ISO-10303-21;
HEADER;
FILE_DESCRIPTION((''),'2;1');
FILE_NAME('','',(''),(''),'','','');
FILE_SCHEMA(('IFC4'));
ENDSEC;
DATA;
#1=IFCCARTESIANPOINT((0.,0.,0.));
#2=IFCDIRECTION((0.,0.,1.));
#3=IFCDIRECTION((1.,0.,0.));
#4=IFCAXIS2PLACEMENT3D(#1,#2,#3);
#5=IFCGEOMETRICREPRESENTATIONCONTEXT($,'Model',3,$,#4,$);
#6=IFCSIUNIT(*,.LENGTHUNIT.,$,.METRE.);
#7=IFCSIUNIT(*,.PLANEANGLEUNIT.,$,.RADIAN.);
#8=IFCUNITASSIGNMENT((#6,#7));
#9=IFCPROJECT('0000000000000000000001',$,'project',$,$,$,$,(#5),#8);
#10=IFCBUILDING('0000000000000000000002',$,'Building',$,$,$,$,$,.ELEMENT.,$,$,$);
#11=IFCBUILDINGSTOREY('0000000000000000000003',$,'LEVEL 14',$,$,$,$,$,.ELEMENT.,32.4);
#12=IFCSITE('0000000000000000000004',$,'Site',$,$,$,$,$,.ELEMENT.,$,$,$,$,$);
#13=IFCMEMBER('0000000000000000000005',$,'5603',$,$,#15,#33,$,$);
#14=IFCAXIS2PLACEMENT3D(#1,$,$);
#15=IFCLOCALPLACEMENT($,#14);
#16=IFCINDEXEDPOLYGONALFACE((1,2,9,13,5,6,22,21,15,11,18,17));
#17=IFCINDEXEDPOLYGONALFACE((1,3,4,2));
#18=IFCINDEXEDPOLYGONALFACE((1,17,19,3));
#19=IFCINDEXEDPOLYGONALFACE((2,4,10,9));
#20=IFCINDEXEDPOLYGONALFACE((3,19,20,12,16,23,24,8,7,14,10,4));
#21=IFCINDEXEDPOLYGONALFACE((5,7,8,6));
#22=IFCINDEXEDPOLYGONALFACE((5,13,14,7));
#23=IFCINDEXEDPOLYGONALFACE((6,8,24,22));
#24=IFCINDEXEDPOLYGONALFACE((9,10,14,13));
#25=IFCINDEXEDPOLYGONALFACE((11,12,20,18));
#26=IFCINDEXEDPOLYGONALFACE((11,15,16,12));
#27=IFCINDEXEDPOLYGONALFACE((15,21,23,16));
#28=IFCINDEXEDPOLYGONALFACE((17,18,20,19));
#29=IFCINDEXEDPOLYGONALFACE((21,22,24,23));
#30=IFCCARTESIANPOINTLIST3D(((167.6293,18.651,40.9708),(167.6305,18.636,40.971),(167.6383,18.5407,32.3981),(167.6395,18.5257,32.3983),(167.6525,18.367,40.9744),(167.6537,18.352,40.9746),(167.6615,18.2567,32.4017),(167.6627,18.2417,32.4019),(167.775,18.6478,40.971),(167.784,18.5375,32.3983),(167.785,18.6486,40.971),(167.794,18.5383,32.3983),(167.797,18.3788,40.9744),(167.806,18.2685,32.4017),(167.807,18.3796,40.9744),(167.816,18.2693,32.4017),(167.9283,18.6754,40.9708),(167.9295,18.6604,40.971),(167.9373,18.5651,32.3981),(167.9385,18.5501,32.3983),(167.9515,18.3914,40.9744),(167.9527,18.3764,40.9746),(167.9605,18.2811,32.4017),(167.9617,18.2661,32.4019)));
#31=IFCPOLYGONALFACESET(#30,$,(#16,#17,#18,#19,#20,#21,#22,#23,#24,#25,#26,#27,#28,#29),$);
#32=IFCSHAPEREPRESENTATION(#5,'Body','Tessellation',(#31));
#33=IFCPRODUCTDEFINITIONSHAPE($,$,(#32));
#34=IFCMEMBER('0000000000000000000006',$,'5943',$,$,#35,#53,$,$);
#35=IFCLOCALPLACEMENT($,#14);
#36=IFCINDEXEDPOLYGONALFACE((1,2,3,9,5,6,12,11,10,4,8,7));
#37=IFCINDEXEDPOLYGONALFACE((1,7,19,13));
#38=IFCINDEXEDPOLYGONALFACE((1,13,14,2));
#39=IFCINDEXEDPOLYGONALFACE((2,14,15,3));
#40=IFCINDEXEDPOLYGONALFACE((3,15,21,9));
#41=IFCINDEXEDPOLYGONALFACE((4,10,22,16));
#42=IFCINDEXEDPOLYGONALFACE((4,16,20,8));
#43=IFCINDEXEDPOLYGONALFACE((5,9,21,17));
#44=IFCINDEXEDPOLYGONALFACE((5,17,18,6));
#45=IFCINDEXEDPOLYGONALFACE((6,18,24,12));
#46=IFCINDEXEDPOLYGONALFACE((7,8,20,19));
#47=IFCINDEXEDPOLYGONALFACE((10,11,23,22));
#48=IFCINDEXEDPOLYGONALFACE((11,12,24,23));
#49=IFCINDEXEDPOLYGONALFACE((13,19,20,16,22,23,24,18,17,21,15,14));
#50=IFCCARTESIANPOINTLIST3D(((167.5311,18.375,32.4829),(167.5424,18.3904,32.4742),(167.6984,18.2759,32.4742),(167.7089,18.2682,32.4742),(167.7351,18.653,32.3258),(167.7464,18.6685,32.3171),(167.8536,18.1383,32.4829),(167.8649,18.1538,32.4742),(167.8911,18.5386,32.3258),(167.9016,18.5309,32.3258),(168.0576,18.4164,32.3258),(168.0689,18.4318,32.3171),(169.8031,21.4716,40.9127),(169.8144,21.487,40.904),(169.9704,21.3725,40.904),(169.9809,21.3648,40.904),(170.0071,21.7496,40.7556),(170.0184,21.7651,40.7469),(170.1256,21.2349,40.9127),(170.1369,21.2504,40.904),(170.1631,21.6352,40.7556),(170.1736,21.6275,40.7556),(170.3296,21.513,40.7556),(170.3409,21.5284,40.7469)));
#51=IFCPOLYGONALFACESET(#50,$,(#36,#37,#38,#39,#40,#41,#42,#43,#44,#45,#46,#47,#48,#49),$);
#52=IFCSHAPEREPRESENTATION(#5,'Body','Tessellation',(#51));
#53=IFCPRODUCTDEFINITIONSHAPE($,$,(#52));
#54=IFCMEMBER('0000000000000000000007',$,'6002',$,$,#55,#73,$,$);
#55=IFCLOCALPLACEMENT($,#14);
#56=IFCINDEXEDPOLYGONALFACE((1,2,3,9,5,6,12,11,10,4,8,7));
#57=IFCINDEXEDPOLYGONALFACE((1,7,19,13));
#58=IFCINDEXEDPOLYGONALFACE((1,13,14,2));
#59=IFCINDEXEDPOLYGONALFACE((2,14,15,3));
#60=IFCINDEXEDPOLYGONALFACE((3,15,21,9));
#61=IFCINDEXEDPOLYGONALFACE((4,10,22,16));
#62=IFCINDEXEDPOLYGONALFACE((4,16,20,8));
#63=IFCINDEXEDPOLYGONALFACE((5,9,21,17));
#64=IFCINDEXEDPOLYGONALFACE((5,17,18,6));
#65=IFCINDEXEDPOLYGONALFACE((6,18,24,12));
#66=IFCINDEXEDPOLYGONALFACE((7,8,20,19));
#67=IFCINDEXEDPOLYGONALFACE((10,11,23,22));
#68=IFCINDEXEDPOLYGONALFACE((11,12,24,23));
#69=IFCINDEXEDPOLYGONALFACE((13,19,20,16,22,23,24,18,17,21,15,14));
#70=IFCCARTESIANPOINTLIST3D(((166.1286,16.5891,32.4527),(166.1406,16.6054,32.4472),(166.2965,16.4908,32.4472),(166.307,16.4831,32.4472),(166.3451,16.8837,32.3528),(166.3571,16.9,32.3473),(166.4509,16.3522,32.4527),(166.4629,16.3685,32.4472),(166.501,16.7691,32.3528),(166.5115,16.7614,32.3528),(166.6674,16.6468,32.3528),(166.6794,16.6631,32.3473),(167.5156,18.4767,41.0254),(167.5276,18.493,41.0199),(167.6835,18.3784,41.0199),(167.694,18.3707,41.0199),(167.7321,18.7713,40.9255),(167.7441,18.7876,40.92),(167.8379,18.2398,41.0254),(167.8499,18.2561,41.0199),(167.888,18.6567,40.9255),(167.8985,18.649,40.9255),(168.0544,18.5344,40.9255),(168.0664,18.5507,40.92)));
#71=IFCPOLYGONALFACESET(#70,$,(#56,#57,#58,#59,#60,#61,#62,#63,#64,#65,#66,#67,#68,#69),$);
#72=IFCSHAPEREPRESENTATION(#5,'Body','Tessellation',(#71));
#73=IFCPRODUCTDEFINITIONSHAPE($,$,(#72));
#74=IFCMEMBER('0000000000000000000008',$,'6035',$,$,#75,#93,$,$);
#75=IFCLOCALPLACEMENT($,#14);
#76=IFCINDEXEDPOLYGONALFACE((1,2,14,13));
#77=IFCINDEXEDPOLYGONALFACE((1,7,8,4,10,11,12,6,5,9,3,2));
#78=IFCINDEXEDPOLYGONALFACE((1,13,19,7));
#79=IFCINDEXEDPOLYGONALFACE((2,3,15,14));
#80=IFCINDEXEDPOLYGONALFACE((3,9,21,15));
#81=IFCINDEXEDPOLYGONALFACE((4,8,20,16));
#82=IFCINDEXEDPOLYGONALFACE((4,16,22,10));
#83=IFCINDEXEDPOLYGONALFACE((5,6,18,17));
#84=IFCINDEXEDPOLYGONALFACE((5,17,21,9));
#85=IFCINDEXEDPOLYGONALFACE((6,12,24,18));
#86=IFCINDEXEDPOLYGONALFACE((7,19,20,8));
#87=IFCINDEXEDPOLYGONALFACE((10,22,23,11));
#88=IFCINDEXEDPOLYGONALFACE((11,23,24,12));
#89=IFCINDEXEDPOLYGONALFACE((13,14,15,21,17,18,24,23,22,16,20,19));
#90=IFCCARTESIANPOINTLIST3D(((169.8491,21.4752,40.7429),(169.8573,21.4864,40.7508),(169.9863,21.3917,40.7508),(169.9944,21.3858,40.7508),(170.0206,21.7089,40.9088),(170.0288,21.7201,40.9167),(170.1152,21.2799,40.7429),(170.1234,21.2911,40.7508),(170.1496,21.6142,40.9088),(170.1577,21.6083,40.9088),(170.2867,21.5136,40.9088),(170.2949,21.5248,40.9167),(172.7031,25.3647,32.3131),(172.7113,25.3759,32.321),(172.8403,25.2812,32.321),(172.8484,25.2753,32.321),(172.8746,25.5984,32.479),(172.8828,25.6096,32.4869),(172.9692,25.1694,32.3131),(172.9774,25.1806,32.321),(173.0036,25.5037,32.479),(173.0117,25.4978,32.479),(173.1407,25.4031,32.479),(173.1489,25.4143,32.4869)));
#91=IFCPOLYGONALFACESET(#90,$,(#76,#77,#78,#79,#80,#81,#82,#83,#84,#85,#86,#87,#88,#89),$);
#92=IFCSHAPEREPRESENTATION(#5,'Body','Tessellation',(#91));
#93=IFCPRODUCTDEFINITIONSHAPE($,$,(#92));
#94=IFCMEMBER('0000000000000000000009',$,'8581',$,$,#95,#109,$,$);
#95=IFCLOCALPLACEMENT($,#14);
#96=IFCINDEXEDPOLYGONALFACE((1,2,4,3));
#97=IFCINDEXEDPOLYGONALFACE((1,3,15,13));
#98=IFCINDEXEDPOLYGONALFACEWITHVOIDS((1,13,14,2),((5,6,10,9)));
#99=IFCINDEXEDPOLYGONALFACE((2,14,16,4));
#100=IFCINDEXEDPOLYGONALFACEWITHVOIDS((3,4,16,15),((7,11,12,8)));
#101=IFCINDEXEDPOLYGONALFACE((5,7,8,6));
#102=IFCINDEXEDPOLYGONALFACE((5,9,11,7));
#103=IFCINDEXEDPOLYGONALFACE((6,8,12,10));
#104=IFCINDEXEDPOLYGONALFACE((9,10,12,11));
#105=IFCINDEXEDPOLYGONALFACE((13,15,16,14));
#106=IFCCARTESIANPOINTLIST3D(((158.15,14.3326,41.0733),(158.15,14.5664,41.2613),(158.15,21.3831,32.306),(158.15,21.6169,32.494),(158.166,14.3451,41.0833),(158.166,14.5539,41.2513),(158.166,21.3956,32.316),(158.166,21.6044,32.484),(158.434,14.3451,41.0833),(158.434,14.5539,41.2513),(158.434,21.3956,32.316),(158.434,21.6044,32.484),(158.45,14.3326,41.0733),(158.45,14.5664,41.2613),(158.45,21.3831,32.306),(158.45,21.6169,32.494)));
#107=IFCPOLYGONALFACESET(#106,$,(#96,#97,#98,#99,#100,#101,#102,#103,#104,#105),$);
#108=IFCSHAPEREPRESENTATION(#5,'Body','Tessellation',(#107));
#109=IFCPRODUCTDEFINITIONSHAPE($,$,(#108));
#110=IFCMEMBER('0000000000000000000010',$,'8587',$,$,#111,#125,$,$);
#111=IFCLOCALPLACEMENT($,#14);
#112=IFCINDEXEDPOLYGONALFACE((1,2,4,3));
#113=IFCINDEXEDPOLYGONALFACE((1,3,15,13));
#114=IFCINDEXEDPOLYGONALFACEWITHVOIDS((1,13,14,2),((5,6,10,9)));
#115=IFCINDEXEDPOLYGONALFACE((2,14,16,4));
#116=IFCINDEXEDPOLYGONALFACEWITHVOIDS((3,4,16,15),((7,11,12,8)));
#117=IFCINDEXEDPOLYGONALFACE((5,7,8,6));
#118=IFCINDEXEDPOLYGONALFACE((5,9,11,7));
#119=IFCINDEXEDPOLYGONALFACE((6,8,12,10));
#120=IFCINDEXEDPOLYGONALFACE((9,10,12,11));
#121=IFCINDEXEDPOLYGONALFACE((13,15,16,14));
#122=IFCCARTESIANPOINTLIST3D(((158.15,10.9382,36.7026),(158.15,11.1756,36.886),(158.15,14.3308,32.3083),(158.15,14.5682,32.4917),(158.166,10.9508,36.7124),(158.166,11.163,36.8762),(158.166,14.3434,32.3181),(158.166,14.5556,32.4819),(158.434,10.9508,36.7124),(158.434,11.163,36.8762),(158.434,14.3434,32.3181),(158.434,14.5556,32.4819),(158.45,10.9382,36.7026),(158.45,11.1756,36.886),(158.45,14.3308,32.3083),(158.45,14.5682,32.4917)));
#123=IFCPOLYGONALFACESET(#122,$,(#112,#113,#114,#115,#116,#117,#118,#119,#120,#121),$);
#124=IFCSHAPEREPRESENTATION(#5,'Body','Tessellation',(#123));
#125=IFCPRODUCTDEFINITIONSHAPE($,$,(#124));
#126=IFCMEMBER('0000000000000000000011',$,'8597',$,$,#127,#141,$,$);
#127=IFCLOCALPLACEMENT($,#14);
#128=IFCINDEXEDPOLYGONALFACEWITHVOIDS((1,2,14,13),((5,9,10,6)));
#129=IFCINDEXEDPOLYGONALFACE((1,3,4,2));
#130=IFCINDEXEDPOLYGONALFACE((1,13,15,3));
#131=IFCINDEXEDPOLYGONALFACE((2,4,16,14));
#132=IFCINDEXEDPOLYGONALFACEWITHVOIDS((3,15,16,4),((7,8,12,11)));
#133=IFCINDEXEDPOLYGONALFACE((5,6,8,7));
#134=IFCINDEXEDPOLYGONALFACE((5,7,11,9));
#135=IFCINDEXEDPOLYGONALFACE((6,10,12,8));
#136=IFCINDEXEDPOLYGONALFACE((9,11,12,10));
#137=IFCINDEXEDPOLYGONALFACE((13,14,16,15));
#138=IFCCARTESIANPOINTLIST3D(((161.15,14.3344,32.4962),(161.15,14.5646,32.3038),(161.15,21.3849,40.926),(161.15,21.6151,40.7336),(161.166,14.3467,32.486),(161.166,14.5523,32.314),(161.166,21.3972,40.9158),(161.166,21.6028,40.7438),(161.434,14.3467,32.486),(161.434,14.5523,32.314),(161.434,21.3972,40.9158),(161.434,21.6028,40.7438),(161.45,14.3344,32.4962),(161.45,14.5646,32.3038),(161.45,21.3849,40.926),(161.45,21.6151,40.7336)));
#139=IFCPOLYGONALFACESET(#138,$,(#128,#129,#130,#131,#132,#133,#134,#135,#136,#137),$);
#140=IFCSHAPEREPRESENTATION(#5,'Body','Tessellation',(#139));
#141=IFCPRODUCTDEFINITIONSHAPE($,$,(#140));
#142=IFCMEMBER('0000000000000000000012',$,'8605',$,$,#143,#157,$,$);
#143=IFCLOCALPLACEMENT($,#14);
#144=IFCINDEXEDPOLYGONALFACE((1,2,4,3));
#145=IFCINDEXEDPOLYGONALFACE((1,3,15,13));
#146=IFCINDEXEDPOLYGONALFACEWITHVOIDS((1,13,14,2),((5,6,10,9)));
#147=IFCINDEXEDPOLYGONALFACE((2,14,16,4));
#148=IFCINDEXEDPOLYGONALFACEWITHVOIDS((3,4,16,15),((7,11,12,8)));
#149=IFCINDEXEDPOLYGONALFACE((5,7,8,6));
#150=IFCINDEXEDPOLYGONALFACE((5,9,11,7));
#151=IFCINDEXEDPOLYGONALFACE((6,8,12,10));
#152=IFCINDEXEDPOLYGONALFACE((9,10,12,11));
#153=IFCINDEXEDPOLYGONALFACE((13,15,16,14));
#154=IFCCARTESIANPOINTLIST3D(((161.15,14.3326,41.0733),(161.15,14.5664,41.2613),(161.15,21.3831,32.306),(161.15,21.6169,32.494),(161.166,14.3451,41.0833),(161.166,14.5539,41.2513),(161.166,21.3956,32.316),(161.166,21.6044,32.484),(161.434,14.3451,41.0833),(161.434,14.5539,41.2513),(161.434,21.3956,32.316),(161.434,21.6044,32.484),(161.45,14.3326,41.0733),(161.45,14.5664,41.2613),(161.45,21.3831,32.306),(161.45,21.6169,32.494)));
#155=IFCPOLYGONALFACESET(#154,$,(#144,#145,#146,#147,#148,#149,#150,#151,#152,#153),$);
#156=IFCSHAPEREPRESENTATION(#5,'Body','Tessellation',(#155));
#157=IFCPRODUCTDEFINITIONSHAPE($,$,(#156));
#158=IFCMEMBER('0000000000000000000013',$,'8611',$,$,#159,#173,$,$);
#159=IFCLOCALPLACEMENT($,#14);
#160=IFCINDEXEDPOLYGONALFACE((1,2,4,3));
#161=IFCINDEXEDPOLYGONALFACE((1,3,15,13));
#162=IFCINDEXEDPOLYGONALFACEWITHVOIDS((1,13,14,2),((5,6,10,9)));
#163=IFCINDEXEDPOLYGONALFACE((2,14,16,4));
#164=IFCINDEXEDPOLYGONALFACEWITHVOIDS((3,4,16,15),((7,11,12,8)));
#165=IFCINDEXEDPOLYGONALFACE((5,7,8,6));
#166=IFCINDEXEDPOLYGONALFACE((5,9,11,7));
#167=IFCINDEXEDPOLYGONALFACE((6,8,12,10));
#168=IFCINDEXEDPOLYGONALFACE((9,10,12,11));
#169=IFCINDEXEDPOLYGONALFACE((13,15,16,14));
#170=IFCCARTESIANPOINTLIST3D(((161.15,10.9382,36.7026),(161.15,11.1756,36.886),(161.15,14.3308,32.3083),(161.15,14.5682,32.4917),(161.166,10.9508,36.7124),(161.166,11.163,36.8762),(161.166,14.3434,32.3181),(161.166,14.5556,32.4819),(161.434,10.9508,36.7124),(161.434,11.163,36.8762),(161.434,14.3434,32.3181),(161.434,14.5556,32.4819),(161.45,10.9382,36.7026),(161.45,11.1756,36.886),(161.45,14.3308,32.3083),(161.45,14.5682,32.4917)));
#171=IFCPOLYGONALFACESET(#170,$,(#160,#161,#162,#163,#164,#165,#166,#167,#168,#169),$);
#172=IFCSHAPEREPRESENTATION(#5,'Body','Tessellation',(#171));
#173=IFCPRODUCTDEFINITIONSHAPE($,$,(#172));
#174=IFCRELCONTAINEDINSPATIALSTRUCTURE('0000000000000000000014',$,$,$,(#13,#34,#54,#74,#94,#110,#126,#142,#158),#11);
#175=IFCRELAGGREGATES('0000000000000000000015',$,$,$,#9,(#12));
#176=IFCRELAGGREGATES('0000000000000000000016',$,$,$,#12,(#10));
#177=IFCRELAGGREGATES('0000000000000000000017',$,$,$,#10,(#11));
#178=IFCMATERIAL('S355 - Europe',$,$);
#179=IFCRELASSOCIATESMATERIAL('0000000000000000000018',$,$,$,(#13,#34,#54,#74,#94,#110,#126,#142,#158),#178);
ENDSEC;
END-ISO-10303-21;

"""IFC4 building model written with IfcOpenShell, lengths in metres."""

from ifc_helpers import new_model, si_unit, frame, origin_with_axes, origin_2d_with_axis, place, context, project, spatial, hollow_rectangle, i_section, extrude, material, material_profile, profile_set, profile_usage, element, save


model = new_model("IFC4")

# Units and contexts
model_context = context("Model", 3, world=origin_with_axes())
ifc_project = project(units=[si_unit("LENGTHUNIT", "METRE"), si_unit("PLANEANGLEUNIT", "RADIAN")], contexts=[model_context])

# Site, building, storey
site = spatial("IfcSite", under=ifc_project, Name="Site", CompositionType="ELEMENT")
building = spatial("IfcBuilding", under=site, Name="Building", CompositionType="ELEMENT")
storey = spatial("IfcBuildingStorey", under=building, Name="LEVEL 14", CompositionType="ELEMENT", Elevation=32.4)

# Shared definitions
ifc_material = material(Name="S355 - Europe")

# Members
ifc_material_profile_1 = material_profile(ifc_material, i_section(OverallWidth=0.3, OverallDepth=0.3, WebThickness=0.01, FlangeThickness=0.015, at=origin_2d_with_axis()))
ifc_profile_set_1 = profile_set([ifc_material_profile_1])
ifc_profile_usage_1 = profile_usage(ifc_profile_set_1, cardinal=10)
member_1_placement = place(None, frame((167.8, 18.4034, 32.4), z_axis=(-0.00105, 0.012865, 0.999917), x_axis=(-0.996688, -0.081325, 0.0)))
element("IfcMember", 1, at=member_1_placement, inside=storey, material=ifc_profile_usage_1, Name="5603", context=model_context, shape_type="SweptSolid", body=[
    extrude(i_section(OverallWidth=0.3, OverallDepth=0.3, WebThickness=0.01, FlangeThickness=0.015, at=origin_2d_with_axis()), origin_with_axes(), (0.0, 0.0, 1.0), 8.5734),
])
ifc_material_profile_2 = material_profile(ifc_material, i_section(OverallWidth=0.4, OverallDepth=0.4, WebThickness=0.013, FlangeThickness=0.021, at=origin_2d_with_axis()))
ifc_profile_set_2 = profile_set([ifc_material_profile_2])
ifc_profile_usage_2 = profile_usage(ifc_profile_set_2, cardinal=10)
member_2_placement = place(None, frame((167.8, 18.4034, 32.4), z_axis=(0.245264, 0.33428, 0.910002), x_axis=(-0.806237, 0.591593, 0.0)))
element("IfcMember", 2, at=member_2_placement, inside=storey, material=ifc_profile_usage_2, Name="5943", context=model_context, shape_type="SweptSolid", body=[
    extrude(i_section(OverallWidth=0.4, OverallDepth=0.4, WebThickness=0.013, FlangeThickness=0.021, at=origin_2d_with_axis()), origin_with_axes(), (0.0, 0.0, 1.0), 9.2635),
])
ifc_material_profile_3 = material_profile(ifc_material, i_section(OverallWidth=0.4, OverallDepth=0.4, WebThickness=0.013, FlangeThickness=0.021, at=origin_2d_with_axis()))
ifc_profile_set_3 = profile_set([ifc_material_profile_3])
ifc_profile_usage_3 = profile_usage(ifc_profile_set_3, cardinal=10)
member_3_placement = place(None, frame((166.404, 16.6261, 32.4), z_axis=(0.156071, 0.212401, 0.964638), x_axis=(-0.805846, 0.592125, 0.0)))
element("IfcMember", 3, at=member_3_placement, inside=storey, material=ifc_profile_usage_3, Name="6002", context=model_context, shape_type="SweptSolid", body=[
    extrude(i_section(OverallWidth=0.4, OverallDepth=0.4, WebThickness=0.013, FlangeThickness=0.021, at=origin_2d_with_axis()), origin_with_axes(), (0.0, 0.0, 1.0), 8.887),
])
ifc_material_profile_4 = material_profile(ifc_material, i_section(OverallWidth=0.33, OverallDepth=0.35, WebThickness=0.01, FlangeThickness=0.016, at=origin_2d_with_axis()))
ifc_profile_set_4 = profile_set([ifc_material_profile_4])
ifc_profile_usage_4 = profile_usage(ifc_profile_set_4, cardinal=10)
member_4_placement = place(None, frame((170.072, 21.5, 40.8298), z_axis=(0.293844, 0.400458, -0.867922), x_axis=(-0.806237, 0.591593, 0.0)))
element("IfcMember", 4, at=member_4_placement, inside=storey, material=ifc_profile_usage_4, Name="6035", context=model_context, shape_type="SweptSolid", body=[
    extrude(i_section(OverallWidth=0.33, OverallDepth=0.35, WebThickness=0.01, FlangeThickness=0.016, at=origin_2d_with_axis()), origin_with_axes(), (0.0, 0.0, 1.0), 9.7126),
])
ifc_material_profile_5 = material_profile(ifc_material, hollow_rectangle(XDim=0.3, YDim=0.3, WallThickness=0.016, at=origin_2d_with_axis()))
ifc_profile_set_5 = profile_set([ifc_material_profile_5])
ifc_profile_usage_5 = profile_usage(ifc_profile_set_5, cardinal=10)
member_5_placement = place(None, frame((158.3, 21.5, 32.4), z_axis=(0.0, -0.62668, 0.779277), x_axis=(1.0, 0.0, 0.0)))
element("IfcMember", 5, at=member_5_placement, inside=storey, material=ifc_profile_usage_5, Name="8581", context=model_context, shape_type="SweptSolid", body=[
    extrude(hollow_rectangle(XDim=0.3, YDim=0.3, WallThickness=0.016, at=origin_2d_with_axis()), origin_with_axes(), (0.0, 0.0, 1.0), 11.2506),
])
ifc_material_profile_6 = material_profile(ifc_material, hollow_rectangle(XDim=0.3, YDim=0.3, WallThickness=0.016, at=origin_2d_with_axis()))
ifc_profile_set_6 = profile_set([ifc_material_profile_6])
ifc_profile_usage_6 = profile_usage(ifc_profile_set_6, cardinal=10)
member_6_placement = place(None, frame((158.3, 14.4495, 32.4), z_axis=(0.0, -0.61111, 0.791546), x_axis=(1.0, 0.0, 0.0)))
element("IfcMember", 6, at=member_6_placement, inside=storey, material=ifc_profile_usage_6, Name="8587", context=model_context, shape_type="SweptSolid", body=[
    extrude(hollow_rectangle(XDim=0.3, YDim=0.3, WallThickness=0.016, at=origin_2d_with_axis()), origin_with_axes(), (0.0, 0.0, 1.0), 5.5515),
])
ifc_material_profile_7 = material_profile(ifc_material, hollow_rectangle(XDim=0.3, YDim=0.3, WallThickness=0.016, at=origin_2d_with_axis()))
ifc_profile_set_7 = profile_set([ifc_material_profile_7])
ifc_profile_usage_7 = profile_usage(ifc_profile_set_7, cardinal=10)
member_7_placement = place(None, frame((161.3, 14.4495, 32.4), z_axis=(0.0, 0.641562, 0.767071), x_axis=(-1.0, 0.0, 0.0)))
element("IfcMember", 7, at=member_7_placement, inside=storey, material=ifc_profile_usage_7, Name="8597", context=model_context, shape_type="SweptSolid", body=[
    extrude(hollow_rectangle(XDim=0.3, YDim=0.3, WallThickness=0.016, at=origin_2d_with_axis()), origin_with_axes(), (0.0, 0.0, 1.0), 10.9896),
])
ifc_material_profile_8 = material_profile(ifc_material, hollow_rectangle(XDim=0.3, YDim=0.3, WallThickness=0.016, at=origin_2d_with_axis()))
ifc_profile_set_8 = profile_set([ifc_material_profile_8])
ifc_profile_usage_8 = profile_usage(ifc_profile_set_8, cardinal=10)
member_8_placement = place(None, frame((161.3, 21.5, 32.4), z_axis=(0.0, -0.62668, 0.779277), x_axis=(1.0, 0.0, 0.0)))
element("IfcMember", 8, at=member_8_placement, inside=storey, material=ifc_profile_usage_8, Name="8605", context=model_context, shape_type="SweptSolid", body=[
    extrude(hollow_rectangle(XDim=0.3, YDim=0.3, WallThickness=0.016, at=origin_2d_with_axis()), origin_with_axes(), (0.0, 0.0, 1.0), 11.2506),
])
ifc_material_profile_9 = material_profile(ifc_material, hollow_rectangle(XDim=0.3, YDim=0.3, WallThickness=0.016, at=origin_2d_with_axis()))
ifc_profile_set_9 = profile_set([ifc_material_profile_9])
ifc_profile_usage_9 = profile_usage(ifc_profile_set_9, cardinal=10)
member_9_placement = place(None, frame((161.3, 14.4495, 32.4), z_axis=(0.0, -0.61111, 0.791546), x_axis=(1.0, 0.0, 0.0)))
element("IfcMember", 9, at=member_9_placement, inside=storey, material=ifc_profile_usage_9, Name="8611", context=model_context, shape_type="SweptSolid", body=[
    extrude(hollow_rectangle(XDim=0.3, YDim=0.3, WallThickness=0.016, at=origin_2d_with_axis()), origin_with_axes(), (0.0, 0.0, 1.0), 5.5515),
])

save(model, "model.ifc")
